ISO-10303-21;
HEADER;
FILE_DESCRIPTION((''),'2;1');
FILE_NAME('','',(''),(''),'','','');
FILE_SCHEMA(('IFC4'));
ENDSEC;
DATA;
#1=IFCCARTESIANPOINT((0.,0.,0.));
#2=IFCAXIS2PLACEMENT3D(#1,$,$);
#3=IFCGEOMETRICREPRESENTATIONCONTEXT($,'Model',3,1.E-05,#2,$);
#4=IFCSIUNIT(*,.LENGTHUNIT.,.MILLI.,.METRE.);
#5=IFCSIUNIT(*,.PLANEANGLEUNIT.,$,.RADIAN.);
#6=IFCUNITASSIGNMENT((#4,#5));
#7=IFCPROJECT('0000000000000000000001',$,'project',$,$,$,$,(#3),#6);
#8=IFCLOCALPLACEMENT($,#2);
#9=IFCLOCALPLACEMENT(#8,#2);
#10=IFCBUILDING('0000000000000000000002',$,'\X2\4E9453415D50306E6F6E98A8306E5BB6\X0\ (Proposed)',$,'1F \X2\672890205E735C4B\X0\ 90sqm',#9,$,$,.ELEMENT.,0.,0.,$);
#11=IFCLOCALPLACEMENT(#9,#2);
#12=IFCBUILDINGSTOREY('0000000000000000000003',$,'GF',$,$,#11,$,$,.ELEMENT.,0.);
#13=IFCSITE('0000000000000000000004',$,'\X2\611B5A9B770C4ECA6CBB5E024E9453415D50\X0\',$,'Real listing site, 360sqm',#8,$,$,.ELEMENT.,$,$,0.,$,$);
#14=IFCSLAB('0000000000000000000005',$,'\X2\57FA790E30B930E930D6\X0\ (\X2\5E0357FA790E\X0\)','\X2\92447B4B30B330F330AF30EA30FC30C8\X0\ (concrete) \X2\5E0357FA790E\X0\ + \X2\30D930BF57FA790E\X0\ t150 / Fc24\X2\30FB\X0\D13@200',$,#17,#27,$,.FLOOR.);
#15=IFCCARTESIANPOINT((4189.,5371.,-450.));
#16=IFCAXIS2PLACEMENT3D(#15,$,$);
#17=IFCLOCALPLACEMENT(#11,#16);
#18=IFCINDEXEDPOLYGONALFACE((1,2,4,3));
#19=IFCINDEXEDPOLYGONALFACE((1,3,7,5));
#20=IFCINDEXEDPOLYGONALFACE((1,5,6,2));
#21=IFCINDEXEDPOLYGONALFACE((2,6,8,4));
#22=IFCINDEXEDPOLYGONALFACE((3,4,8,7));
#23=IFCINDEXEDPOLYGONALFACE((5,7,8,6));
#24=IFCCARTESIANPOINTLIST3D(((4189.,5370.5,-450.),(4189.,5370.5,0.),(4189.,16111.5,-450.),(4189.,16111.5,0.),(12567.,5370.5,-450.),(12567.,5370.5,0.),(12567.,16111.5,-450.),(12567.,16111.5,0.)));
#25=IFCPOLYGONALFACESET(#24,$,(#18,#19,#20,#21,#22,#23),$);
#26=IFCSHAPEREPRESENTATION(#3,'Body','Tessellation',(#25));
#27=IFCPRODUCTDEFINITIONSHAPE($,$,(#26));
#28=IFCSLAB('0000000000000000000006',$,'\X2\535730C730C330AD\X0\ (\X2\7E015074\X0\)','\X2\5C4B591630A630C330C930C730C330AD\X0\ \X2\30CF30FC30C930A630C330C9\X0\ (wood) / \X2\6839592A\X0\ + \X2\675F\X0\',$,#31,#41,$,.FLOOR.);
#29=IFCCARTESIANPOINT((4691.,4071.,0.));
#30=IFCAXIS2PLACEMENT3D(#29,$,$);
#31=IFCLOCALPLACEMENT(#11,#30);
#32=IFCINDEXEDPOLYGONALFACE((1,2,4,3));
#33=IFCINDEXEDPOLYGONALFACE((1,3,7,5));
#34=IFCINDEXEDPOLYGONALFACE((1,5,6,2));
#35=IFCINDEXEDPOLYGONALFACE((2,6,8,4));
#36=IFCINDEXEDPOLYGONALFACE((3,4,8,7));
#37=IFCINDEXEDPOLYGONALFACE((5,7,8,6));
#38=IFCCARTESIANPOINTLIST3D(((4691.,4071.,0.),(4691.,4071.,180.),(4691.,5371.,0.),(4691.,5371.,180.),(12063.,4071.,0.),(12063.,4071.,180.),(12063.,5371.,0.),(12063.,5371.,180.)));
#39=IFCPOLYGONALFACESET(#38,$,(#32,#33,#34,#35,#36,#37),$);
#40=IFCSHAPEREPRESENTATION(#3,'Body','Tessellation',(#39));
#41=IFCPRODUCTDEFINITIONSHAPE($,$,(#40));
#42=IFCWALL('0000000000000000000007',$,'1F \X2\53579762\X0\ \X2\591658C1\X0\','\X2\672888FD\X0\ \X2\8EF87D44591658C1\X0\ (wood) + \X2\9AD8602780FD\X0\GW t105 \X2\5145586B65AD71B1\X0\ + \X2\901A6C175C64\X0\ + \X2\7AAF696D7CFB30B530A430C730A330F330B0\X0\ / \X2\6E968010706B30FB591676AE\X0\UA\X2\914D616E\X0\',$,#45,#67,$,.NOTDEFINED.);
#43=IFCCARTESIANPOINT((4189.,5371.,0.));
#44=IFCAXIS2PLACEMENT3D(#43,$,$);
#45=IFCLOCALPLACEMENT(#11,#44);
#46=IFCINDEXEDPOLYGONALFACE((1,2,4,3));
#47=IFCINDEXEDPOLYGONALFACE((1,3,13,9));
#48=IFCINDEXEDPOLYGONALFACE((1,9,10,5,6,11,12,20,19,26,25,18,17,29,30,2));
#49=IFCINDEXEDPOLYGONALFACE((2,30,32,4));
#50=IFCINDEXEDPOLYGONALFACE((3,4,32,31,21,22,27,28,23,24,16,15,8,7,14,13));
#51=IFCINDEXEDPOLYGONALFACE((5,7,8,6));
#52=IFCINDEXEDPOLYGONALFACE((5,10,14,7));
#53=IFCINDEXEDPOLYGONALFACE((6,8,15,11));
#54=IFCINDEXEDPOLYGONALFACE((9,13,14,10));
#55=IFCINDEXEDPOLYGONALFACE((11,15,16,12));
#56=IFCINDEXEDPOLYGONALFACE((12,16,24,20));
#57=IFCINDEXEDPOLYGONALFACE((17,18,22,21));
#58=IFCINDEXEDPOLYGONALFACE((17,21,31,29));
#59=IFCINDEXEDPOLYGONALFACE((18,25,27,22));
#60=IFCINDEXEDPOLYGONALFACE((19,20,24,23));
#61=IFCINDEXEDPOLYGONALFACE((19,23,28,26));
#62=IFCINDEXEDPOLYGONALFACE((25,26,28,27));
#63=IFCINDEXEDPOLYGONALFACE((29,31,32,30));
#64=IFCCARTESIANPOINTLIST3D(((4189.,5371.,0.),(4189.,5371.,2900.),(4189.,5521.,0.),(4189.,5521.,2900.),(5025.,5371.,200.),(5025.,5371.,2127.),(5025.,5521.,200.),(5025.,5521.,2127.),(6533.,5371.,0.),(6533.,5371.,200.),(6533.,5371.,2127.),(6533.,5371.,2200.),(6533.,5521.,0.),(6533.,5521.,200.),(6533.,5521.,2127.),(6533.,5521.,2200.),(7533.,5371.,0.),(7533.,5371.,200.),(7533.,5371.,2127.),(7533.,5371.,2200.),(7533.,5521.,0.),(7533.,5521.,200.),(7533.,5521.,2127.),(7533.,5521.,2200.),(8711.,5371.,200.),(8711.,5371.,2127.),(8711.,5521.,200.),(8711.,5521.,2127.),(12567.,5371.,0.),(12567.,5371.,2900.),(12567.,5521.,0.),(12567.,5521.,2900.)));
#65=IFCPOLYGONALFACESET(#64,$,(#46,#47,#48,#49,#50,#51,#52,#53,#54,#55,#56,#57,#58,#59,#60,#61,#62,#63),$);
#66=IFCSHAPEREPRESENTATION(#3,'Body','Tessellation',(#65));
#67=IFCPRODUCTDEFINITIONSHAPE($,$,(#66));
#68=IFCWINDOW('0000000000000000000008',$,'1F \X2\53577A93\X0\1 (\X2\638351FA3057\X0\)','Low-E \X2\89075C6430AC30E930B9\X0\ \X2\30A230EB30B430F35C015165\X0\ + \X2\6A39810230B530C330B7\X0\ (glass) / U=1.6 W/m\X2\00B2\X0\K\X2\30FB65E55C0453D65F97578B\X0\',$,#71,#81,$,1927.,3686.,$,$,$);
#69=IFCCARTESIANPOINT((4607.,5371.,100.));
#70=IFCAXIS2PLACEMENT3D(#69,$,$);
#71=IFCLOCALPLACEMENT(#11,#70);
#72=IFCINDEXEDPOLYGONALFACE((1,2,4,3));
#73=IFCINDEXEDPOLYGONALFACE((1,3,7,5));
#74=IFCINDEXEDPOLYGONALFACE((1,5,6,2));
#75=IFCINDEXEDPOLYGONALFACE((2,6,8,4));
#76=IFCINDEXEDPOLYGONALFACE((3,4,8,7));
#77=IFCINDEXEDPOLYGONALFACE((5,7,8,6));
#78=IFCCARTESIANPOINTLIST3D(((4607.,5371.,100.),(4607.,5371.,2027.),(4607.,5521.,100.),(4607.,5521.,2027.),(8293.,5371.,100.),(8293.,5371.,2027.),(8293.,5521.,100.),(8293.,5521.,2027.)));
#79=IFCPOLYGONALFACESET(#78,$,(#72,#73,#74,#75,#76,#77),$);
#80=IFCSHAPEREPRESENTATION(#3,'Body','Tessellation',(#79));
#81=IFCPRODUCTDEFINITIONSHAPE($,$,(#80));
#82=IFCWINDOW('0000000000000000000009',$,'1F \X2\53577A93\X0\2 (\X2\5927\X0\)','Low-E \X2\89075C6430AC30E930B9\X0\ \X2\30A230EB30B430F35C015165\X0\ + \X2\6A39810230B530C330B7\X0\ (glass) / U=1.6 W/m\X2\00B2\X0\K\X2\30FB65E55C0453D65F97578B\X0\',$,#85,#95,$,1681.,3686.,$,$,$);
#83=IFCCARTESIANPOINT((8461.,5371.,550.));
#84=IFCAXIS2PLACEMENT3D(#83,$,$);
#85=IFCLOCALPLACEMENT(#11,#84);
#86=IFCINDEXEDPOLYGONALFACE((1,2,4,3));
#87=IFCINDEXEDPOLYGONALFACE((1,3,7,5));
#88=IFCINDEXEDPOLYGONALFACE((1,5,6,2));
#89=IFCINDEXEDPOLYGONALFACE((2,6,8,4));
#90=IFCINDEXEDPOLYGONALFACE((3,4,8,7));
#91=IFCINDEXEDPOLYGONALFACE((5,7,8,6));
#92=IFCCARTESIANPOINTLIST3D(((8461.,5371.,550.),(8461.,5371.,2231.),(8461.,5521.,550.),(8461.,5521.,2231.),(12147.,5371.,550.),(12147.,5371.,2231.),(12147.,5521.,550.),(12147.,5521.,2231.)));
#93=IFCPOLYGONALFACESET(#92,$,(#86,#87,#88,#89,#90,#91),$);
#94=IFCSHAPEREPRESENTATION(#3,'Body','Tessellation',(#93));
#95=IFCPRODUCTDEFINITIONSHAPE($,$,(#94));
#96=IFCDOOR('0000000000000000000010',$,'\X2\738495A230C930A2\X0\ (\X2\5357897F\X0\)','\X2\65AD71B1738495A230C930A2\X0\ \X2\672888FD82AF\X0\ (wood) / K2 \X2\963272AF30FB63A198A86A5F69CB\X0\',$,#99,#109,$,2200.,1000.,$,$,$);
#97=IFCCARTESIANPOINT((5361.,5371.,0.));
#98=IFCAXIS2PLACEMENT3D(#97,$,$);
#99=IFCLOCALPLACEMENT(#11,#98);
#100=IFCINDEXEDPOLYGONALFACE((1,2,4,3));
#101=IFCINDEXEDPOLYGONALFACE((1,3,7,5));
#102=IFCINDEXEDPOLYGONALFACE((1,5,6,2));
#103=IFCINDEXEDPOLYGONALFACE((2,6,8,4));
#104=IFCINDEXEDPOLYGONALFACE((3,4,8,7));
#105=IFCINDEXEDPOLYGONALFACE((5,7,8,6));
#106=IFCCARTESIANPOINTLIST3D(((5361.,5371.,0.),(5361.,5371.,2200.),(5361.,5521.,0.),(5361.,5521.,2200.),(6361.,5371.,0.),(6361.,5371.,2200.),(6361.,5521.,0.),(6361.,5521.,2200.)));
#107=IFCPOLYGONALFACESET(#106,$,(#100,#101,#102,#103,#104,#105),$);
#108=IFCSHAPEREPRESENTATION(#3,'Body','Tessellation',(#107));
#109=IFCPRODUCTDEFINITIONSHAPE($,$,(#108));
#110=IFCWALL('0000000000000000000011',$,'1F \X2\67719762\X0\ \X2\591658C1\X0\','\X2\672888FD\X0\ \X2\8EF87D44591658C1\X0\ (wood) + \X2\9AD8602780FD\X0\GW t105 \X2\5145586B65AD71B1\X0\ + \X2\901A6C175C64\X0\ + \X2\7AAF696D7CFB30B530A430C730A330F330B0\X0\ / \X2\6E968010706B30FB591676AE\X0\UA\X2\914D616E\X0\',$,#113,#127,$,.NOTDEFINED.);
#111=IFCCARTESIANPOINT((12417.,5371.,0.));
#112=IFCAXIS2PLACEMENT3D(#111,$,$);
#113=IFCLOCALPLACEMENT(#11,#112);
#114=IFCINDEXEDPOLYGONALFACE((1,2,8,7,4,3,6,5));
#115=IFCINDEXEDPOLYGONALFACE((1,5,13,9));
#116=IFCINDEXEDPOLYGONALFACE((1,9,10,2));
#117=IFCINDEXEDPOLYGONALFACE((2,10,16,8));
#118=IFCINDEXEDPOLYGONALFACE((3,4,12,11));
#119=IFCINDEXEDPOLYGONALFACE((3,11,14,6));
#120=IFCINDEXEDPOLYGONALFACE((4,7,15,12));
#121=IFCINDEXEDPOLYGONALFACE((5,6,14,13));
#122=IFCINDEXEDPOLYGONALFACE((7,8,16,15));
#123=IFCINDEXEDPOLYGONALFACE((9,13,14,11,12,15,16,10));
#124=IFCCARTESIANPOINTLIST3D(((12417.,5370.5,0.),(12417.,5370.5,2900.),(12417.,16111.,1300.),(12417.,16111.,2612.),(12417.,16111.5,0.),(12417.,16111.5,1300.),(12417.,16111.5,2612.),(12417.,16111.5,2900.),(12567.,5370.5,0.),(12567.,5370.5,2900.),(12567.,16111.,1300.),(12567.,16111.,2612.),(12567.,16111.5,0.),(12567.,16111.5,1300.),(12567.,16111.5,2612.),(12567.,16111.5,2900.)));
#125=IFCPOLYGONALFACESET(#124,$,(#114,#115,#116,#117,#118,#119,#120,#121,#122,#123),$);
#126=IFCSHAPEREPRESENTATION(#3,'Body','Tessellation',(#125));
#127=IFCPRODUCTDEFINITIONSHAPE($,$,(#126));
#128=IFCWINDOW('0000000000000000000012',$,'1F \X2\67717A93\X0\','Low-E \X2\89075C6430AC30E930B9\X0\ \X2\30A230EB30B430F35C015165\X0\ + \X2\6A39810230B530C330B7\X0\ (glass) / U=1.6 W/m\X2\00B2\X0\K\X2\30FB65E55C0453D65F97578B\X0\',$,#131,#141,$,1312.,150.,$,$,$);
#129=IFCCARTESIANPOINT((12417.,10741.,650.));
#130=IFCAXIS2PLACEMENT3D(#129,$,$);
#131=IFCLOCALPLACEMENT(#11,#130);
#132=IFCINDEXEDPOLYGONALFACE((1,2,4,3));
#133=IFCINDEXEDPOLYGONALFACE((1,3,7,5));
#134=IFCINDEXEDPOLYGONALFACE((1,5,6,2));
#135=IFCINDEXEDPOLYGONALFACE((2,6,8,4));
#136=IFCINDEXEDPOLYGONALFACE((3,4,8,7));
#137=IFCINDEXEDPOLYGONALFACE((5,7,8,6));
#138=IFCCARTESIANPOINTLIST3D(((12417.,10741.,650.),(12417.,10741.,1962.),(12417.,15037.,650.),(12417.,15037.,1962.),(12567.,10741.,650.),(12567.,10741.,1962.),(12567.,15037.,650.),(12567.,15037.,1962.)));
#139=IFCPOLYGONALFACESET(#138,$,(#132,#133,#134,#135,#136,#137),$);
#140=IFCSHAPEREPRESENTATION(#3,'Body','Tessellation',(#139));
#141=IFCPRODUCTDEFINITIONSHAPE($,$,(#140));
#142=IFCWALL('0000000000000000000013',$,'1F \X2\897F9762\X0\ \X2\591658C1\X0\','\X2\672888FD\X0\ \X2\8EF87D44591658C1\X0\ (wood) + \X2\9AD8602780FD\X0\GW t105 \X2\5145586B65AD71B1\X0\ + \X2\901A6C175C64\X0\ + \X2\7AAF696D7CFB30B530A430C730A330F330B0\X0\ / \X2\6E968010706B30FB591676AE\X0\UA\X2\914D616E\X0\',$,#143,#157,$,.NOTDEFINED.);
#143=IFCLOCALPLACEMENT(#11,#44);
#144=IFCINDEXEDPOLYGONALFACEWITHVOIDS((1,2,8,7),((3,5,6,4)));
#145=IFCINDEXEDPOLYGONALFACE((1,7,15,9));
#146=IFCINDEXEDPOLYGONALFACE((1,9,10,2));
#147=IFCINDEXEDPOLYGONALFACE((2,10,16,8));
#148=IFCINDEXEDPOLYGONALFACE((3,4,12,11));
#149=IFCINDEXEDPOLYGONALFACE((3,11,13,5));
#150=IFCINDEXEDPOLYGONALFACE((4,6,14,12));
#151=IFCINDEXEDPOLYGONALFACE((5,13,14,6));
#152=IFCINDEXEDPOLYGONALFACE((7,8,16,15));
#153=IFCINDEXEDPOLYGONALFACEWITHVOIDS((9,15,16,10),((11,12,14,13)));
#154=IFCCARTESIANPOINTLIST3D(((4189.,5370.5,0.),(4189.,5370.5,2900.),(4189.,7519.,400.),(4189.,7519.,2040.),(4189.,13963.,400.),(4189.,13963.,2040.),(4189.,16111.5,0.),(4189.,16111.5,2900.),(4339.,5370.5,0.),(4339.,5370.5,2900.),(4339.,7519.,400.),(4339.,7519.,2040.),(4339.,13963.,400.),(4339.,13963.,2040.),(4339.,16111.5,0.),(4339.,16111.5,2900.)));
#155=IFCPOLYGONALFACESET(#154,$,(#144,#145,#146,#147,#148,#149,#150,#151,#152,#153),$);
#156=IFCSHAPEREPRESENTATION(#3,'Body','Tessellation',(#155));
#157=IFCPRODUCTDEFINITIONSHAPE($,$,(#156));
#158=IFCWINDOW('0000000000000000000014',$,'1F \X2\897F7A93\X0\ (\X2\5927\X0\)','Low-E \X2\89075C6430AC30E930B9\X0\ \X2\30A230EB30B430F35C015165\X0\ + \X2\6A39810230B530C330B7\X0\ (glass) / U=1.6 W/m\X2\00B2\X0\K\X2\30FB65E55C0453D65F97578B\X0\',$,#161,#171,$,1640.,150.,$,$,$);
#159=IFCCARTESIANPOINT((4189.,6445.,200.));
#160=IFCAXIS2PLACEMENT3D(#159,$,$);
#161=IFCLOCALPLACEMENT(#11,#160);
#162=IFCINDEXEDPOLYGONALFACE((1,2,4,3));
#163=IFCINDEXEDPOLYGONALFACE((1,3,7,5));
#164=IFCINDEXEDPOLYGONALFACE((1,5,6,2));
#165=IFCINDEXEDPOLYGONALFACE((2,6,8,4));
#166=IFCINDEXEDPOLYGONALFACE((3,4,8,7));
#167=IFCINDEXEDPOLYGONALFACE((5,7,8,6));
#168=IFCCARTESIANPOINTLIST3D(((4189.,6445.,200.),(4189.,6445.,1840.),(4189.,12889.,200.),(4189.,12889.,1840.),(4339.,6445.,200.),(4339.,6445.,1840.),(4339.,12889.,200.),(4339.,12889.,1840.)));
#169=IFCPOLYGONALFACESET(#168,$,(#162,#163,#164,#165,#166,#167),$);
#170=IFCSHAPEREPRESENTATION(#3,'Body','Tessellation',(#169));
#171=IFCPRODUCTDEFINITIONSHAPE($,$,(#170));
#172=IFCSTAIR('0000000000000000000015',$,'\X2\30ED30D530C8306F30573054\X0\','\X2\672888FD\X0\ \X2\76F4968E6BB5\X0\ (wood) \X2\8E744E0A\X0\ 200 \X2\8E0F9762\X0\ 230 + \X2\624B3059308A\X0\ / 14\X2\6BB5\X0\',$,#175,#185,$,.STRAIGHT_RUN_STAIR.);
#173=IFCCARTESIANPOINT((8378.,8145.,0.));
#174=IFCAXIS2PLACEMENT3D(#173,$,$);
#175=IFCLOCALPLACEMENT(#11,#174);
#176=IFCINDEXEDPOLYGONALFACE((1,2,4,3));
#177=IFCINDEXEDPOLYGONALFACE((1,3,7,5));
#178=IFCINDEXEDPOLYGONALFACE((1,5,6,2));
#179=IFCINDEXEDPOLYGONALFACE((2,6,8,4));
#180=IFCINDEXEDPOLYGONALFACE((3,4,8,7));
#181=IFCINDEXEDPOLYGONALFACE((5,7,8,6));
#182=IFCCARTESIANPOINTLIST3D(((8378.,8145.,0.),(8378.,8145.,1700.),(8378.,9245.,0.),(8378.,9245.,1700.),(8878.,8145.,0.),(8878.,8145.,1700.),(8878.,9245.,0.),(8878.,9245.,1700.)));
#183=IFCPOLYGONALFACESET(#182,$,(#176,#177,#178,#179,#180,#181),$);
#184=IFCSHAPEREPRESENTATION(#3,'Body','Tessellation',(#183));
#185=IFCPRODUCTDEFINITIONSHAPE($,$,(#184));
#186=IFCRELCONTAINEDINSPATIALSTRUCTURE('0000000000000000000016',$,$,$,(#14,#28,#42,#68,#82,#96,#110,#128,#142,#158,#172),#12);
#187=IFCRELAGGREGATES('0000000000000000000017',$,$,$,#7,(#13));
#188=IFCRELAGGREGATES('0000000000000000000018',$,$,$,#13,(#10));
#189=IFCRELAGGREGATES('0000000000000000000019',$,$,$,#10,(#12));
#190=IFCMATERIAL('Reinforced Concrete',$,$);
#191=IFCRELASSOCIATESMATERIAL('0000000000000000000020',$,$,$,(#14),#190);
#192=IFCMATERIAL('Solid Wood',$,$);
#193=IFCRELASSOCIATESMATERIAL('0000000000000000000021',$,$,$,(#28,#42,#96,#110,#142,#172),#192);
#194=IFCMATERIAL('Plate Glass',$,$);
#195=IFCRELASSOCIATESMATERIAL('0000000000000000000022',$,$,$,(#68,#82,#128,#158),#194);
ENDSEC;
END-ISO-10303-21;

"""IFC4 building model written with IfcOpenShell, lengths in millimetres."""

from ifc_helpers import new_model, si_unit, frame, frame_2d, origin, place, context, project, spatial, rectangle, extrude, material, element, fill, save


model = new_model("IFC4")

# Units and contexts
model_context = context("Model", 3, precision=1e-05, world=origin())
ifc_project = project(units=[si_unit("LENGTHUNIT", "METRE", prefix="MILLI"), si_unit("PLANEANGLEUNIT", "RADIAN")], contexts=[model_context])

# Site, building, storey
site_placement = place(None, origin())
site = spatial("IfcSite", under=ifc_project, at=site_placement, Name="愛媛県今治市五十嵐", ObjectType="Real listing site, 360sqm", CompositionType="ELEMENT", RefElevation=0.0)
building_placement = place(site_placement, origin())
building = spatial("IfcBuilding", under=site, at=building_placement, Name="五十嵐の潮風の家 (Proposed)", ObjectType="1F 木造平屋 90sqm", CompositionType="ELEMENT", ElevationOfRefHeight=0.0, ElevationOfTerrain=0.0)
storey_placement = place(building_placement, origin())
storey = spatial("IfcBuildingStorey", under=building, at=storey_placement, Name="GF", CompositionType="ELEMENT", Elevation=0.0)

# Slabs
ifc_material_1 = material(Name="Reinforced Concrete")
slab_1_placement = place(storey_placement, frame((4189.0, 5371.0, -450.0)))
element("IfcSlab", 1, at=slab_1_placement, inside=storey, material=ifc_material_1, Name="基礎スラブ (布基礎)", Description="鉄筋コンクリート (concrete) 布基礎 + ベタ基礎 t150 / Fc24・D13@200", PredefinedType="FLOOR", context=model_context, shape_type="SweptSolid", body=[
    extrude(rectangle(XDim=8378.0, YDim=10741.0, at=frame_2d((4189.0, 5370.0))), frame((4189.0, 5371.0, -450.0)), (0.0, 0.0, 1.0), 450.0),
])
ifc_material_2 = material(Name="Solid Wood")
slab_2_placement = place(storey_placement, frame((4691.0, 4071.0, 0.0)))
element("IfcSlab", 2, at=slab_2_placement, inside=storey, material=ifc_material_2, Name="南デッキ (縁側)", Description="屋外ウッドデッキ ハードウッド (wood) / 根太 + 束", PredefinedType="FLOOR", context=model_context, shape_type="SweptSolid", body=[
    extrude(rectangle(XDim=7372.0, YDim=1300.0, at=frame_2d((3686.0, 650.0))), frame((4691.0, 4071.0, 0.0)), (0.0, 0.0, 1.0), 180.0),
])

# Wall, openings, windows, door
wall_1_placement = place(storey_placement, frame((4189.0, 5371.0, 0.0)))
wall_1 = element("IfcWall", 3, at=wall_1_placement, inside=storey, material=ifc_material_2, Name="1F 南面 外壁", Description="木製 軸組外壁 (wood) + 高性能GW t105 充填断熱 + 通気層 + 窯業系サイディング / 準耐火・外皮UA配慮", PredefinedType="NOTDEFINED", context=model_context, shape_type="SweptSolid", body=[
    extrude(rectangle(XDim=8378.0, YDim=150.0, at=frame_2d((4189.0, 75.0))), frame((4189.0, 5371.0, 0.0)), (0.0, 0.0, 1.0), 2900.0),
])
opening_1_placement = place(storey_placement, frame((4607.0, 5371.0, 100.0)))
opening_1 = element("IfcOpeningElement", 4, at=opening_1_placement, cuts=wall_1, PredefinedType="NOTDEFINED", context=model_context, shape_type="SweptSolid", body=[
    extrude(rectangle(XDim=3686.0, YDim=150.0, at=frame_2d((1843.0, 75.0))), frame((4607.0, 5371.0, 100.0)), (0.0, 0.0, 1.0), 1927.0),
])
opening_2_placement = place(storey_placement, frame((8461.0, 5371.0, 550.0)))
opening_2 = element("IfcOpeningElement", 5, at=opening_2_placement, cuts=wall_1, PredefinedType="NOTDEFINED", context=model_context, shape_type="SweptSolid", body=[
    extrude(rectangle(XDim=3686.0, YDim=150.0, at=frame_2d((1843.0, 75.0))), frame((8461.0, 5371.0, 550.0)), (0.0, 0.0, 1.0), 1681.0),
])
opening_3_placement = place(storey_placement, frame((5361.0, 5371.0, 0.0)))
opening_3 = element("IfcOpeningElement", 6, at=opening_3_placement, cuts=wall_1, PredefinedType="NOTDEFINED", context=model_context, shape_type="SweptSolid", body=[
    extrude(rectangle(XDim=1000.0, YDim=150.0, at=frame_2d((500.0, 75.0))), frame((5361.0, 5371.0, 0.0)), (0.0, 0.0, 1.0), 2200.0),
])
ifc_material_3 = material(Name="Plate Glass")
window_1_placement = place(storey_placement, frame((4607.0, 5371.0, 100.0)))
window_1 = element("IfcWindow", 7, at=window_1_placement, inside=storey, material=ifc_material_3, Name="1F 南窓1 (掃出し)", Description="Low-E 複層ガラス アルゴン封入 + 樹脂サッシ (glass) / U=1.6 W/m²K・日射取得型", OverallHeight=1927.0, OverallWidth=3686.0, context=model_context, shape_type="SweptSolid", body=[
    extrude(rectangle(XDim=3686.0, YDim=150.0, at=frame_2d((1843.0, 75.0))), frame((4607.0, 5371.0, 100.0)), (0.0, 0.0, 1.0), 1927.0),
])
fill(opening_1, window_1)
window_2_placement = place(storey_placement, frame((8461.0, 5371.0, 550.0)))
window_2 = element("IfcWindow", 8, at=window_2_placement, inside=storey, material=ifc_material_3, Name="1F 南窓2 (大)", Description="Low-E 複層ガラス アルゴン封入 + 樹脂サッシ (glass) / U=1.6 W/m²K・日射取得型", OverallHeight=1681.0, OverallWidth=3686.0, context=model_context, shape_type="SweptSolid", body=[
    extrude(rectangle(XDim=3686.0, YDim=150.0, at=frame_2d((1843.0, 75.0))), frame((8461.0, 5371.0, 550.0)), (0.0, 0.0, 1.0), 1681.0),
])
fill(opening_2, window_2)
door_placement = place(storey_placement, frame((5361.0, 5371.0, 0.0)))
door = element("IfcDoor", 9, at=door_placement, inside=storey, material=ifc_material_2, Name="玄関ドア (南西)", Description="断熱玄関ドア 木製芯 (wood) / K2 防犯・採風機構", OverallHeight=2200.0, OverallWidth=1000.0, context=model_context, shape_type="SweptSolid", body=[
    extrude(rectangle(XDim=1000.0, YDim=150.0, at=frame_2d((500.0, 75.0))), frame((5361.0, 5371.0, 0.0)), (0.0, 0.0, 1.0), 2200.0),
])
fill(opening_3, door)

# Walls, openings, windows
wall_2_placement = place(storey_placement, frame((12417.0, 5371.0, 0.0)))
wall_2 = element("IfcWall", 10, at=wall_2_placement, inside=storey, material=ifc_material_2, Name="1F 東面 外壁", Description="木製 軸組外壁 (wood) + 高性能GW t105 充填断熱 + 通気層 + 窯業系サイディング / 準耐火・外皮UA配慮", PredefinedType="NOTDEFINED", context=model_context, shape_type="SweptSolid", body=[
    extrude(rectangle(XDim=150.0, YDim=10741.0, at=frame_2d((75.0, 5370.0))), frame((12417.0, 5371.0, 0.0)), (0.0, 0.0, 1.0), 2900.0),
])
opening_4_placement = place(storey_placement, frame((12417.0, 10741.0, 650.0)))
opening_4 = element("IfcOpeningElement", 11, at=opening_4_placement, cuts=wall_2, PredefinedType="NOTDEFINED", context=model_context, shape_type="SweptSolid", body=[
    extrude(rectangle(XDim=150.0, YDim=4296.0, at=frame_2d((75.0, 2148.0))), frame((12417.0, 10741.0, 650.0)), (0.0, 0.0, 1.0), 1312.0),
])
window_3_placement = place(storey_placement, frame((12417.0, 10741.0, 650.0)))
window_3 = element("IfcWindow", 12, at=window_3_placement, inside=storey, material=ifc_material_3, Name="1F 東窓", Description="Low-E 複層ガラス アルゴン封入 + 樹脂サッシ (glass) / U=1.6 W/m²K・日射取得型", OverallHeight=1312.0, OverallWidth=150.0, context=model_context, shape_type="SweptSolid", body=[
    extrude(rectangle(XDim=150.0, YDim=4296.0, at=frame_2d((75.0, 2148.0))), frame((12417.0, 10741.0, 650.0)), (0.0, 0.0, 1.0), 1312.0),
])
fill(opening_4, window_3)
wall_3_placement = place(storey_placement, frame((4189.0, 5371.0, 0.0)))
wall_3 = element("IfcWall", 13, at=wall_3_placement, inside=storey, material=ifc_material_2, Name="1F 西面 外壁", Description="木製 軸組外壁 (wood) + 高性能GW t105 充填断熱 + 通気層 + 窯業系サイディング / 準耐火・外皮UA配慮", PredefinedType="NOTDEFINED", context=model_context, shape_type="SweptSolid", body=[
    extrude(rectangle(XDim=150.0, YDim=10741.0, at=frame_2d((75.0, 5370.0))), frame((4189.0, 5371.0, 0.0)), (0.0, 0.0, 1.0), 2900.0),
])
opening_5_placement = place(storey_placement, frame((4189.0, 6445.0, 200.0)))
opening_5 = element("IfcOpeningElement", 14, at=opening_5_placement, cuts=wall_3, PredefinedType="NOTDEFINED", context=model_context, shape_type="SweptSolid", body=[
    extrude(rectangle(XDim=150.0, YDim=6444.0, at=frame_2d((75.0, 3222.0))), frame((4189.0, 6445.0, 200.0)), (0.0, 0.0, 1.0), 1640.0),
])
window_4_placement = place(storey_placement, frame((4189.0, 6445.0, 200.0)))
window_4 = element("IfcWindow", 15, at=window_4_placement, inside=storey, material=ifc_material_3, Name="1F 西窓 (大)", Description="Low-E 複層ガラス アルゴン封入 + 樹脂サッシ (glass) / U=1.6 W/m²K・日射取得型", OverallHeight=1640.0, OverallWidth=150.0, context=model_context, shape_type="SweptSolid", body=[
    extrude(rectangle(XDim=150.0, YDim=6444.0, at=frame_2d((75.0, 3222.0))), frame((4189.0, 6445.0, 200.0)), (0.0, 0.0, 1.0), 1640.0),
])
fill(opening_5, window_4)

# Stair
stair_placement = place(storey_placement, frame((8378.0, 8145.0, 0.0)))
element("IfcStair", 16, at=stair_placement, inside=storey, material=ifc_material_2, Name="ロフトはしご", Description="木製 直階段 (wood) 蹴上 200 踏面 230 + 手すり / 14段", PredefinedType="STRAIGHT_RUN_STAIR", context=model_context, shape_type="SweptSolid", body=[
    extrude(rectangle(XDim=500.0, YDim=1100.0, at=frame_2d((250.0, 550.0))), frame((8378.0, 8145.0, 0.0)), (0.0, 0.0, 1.0), 1700.0),
])

save(model, "model.ifc")
